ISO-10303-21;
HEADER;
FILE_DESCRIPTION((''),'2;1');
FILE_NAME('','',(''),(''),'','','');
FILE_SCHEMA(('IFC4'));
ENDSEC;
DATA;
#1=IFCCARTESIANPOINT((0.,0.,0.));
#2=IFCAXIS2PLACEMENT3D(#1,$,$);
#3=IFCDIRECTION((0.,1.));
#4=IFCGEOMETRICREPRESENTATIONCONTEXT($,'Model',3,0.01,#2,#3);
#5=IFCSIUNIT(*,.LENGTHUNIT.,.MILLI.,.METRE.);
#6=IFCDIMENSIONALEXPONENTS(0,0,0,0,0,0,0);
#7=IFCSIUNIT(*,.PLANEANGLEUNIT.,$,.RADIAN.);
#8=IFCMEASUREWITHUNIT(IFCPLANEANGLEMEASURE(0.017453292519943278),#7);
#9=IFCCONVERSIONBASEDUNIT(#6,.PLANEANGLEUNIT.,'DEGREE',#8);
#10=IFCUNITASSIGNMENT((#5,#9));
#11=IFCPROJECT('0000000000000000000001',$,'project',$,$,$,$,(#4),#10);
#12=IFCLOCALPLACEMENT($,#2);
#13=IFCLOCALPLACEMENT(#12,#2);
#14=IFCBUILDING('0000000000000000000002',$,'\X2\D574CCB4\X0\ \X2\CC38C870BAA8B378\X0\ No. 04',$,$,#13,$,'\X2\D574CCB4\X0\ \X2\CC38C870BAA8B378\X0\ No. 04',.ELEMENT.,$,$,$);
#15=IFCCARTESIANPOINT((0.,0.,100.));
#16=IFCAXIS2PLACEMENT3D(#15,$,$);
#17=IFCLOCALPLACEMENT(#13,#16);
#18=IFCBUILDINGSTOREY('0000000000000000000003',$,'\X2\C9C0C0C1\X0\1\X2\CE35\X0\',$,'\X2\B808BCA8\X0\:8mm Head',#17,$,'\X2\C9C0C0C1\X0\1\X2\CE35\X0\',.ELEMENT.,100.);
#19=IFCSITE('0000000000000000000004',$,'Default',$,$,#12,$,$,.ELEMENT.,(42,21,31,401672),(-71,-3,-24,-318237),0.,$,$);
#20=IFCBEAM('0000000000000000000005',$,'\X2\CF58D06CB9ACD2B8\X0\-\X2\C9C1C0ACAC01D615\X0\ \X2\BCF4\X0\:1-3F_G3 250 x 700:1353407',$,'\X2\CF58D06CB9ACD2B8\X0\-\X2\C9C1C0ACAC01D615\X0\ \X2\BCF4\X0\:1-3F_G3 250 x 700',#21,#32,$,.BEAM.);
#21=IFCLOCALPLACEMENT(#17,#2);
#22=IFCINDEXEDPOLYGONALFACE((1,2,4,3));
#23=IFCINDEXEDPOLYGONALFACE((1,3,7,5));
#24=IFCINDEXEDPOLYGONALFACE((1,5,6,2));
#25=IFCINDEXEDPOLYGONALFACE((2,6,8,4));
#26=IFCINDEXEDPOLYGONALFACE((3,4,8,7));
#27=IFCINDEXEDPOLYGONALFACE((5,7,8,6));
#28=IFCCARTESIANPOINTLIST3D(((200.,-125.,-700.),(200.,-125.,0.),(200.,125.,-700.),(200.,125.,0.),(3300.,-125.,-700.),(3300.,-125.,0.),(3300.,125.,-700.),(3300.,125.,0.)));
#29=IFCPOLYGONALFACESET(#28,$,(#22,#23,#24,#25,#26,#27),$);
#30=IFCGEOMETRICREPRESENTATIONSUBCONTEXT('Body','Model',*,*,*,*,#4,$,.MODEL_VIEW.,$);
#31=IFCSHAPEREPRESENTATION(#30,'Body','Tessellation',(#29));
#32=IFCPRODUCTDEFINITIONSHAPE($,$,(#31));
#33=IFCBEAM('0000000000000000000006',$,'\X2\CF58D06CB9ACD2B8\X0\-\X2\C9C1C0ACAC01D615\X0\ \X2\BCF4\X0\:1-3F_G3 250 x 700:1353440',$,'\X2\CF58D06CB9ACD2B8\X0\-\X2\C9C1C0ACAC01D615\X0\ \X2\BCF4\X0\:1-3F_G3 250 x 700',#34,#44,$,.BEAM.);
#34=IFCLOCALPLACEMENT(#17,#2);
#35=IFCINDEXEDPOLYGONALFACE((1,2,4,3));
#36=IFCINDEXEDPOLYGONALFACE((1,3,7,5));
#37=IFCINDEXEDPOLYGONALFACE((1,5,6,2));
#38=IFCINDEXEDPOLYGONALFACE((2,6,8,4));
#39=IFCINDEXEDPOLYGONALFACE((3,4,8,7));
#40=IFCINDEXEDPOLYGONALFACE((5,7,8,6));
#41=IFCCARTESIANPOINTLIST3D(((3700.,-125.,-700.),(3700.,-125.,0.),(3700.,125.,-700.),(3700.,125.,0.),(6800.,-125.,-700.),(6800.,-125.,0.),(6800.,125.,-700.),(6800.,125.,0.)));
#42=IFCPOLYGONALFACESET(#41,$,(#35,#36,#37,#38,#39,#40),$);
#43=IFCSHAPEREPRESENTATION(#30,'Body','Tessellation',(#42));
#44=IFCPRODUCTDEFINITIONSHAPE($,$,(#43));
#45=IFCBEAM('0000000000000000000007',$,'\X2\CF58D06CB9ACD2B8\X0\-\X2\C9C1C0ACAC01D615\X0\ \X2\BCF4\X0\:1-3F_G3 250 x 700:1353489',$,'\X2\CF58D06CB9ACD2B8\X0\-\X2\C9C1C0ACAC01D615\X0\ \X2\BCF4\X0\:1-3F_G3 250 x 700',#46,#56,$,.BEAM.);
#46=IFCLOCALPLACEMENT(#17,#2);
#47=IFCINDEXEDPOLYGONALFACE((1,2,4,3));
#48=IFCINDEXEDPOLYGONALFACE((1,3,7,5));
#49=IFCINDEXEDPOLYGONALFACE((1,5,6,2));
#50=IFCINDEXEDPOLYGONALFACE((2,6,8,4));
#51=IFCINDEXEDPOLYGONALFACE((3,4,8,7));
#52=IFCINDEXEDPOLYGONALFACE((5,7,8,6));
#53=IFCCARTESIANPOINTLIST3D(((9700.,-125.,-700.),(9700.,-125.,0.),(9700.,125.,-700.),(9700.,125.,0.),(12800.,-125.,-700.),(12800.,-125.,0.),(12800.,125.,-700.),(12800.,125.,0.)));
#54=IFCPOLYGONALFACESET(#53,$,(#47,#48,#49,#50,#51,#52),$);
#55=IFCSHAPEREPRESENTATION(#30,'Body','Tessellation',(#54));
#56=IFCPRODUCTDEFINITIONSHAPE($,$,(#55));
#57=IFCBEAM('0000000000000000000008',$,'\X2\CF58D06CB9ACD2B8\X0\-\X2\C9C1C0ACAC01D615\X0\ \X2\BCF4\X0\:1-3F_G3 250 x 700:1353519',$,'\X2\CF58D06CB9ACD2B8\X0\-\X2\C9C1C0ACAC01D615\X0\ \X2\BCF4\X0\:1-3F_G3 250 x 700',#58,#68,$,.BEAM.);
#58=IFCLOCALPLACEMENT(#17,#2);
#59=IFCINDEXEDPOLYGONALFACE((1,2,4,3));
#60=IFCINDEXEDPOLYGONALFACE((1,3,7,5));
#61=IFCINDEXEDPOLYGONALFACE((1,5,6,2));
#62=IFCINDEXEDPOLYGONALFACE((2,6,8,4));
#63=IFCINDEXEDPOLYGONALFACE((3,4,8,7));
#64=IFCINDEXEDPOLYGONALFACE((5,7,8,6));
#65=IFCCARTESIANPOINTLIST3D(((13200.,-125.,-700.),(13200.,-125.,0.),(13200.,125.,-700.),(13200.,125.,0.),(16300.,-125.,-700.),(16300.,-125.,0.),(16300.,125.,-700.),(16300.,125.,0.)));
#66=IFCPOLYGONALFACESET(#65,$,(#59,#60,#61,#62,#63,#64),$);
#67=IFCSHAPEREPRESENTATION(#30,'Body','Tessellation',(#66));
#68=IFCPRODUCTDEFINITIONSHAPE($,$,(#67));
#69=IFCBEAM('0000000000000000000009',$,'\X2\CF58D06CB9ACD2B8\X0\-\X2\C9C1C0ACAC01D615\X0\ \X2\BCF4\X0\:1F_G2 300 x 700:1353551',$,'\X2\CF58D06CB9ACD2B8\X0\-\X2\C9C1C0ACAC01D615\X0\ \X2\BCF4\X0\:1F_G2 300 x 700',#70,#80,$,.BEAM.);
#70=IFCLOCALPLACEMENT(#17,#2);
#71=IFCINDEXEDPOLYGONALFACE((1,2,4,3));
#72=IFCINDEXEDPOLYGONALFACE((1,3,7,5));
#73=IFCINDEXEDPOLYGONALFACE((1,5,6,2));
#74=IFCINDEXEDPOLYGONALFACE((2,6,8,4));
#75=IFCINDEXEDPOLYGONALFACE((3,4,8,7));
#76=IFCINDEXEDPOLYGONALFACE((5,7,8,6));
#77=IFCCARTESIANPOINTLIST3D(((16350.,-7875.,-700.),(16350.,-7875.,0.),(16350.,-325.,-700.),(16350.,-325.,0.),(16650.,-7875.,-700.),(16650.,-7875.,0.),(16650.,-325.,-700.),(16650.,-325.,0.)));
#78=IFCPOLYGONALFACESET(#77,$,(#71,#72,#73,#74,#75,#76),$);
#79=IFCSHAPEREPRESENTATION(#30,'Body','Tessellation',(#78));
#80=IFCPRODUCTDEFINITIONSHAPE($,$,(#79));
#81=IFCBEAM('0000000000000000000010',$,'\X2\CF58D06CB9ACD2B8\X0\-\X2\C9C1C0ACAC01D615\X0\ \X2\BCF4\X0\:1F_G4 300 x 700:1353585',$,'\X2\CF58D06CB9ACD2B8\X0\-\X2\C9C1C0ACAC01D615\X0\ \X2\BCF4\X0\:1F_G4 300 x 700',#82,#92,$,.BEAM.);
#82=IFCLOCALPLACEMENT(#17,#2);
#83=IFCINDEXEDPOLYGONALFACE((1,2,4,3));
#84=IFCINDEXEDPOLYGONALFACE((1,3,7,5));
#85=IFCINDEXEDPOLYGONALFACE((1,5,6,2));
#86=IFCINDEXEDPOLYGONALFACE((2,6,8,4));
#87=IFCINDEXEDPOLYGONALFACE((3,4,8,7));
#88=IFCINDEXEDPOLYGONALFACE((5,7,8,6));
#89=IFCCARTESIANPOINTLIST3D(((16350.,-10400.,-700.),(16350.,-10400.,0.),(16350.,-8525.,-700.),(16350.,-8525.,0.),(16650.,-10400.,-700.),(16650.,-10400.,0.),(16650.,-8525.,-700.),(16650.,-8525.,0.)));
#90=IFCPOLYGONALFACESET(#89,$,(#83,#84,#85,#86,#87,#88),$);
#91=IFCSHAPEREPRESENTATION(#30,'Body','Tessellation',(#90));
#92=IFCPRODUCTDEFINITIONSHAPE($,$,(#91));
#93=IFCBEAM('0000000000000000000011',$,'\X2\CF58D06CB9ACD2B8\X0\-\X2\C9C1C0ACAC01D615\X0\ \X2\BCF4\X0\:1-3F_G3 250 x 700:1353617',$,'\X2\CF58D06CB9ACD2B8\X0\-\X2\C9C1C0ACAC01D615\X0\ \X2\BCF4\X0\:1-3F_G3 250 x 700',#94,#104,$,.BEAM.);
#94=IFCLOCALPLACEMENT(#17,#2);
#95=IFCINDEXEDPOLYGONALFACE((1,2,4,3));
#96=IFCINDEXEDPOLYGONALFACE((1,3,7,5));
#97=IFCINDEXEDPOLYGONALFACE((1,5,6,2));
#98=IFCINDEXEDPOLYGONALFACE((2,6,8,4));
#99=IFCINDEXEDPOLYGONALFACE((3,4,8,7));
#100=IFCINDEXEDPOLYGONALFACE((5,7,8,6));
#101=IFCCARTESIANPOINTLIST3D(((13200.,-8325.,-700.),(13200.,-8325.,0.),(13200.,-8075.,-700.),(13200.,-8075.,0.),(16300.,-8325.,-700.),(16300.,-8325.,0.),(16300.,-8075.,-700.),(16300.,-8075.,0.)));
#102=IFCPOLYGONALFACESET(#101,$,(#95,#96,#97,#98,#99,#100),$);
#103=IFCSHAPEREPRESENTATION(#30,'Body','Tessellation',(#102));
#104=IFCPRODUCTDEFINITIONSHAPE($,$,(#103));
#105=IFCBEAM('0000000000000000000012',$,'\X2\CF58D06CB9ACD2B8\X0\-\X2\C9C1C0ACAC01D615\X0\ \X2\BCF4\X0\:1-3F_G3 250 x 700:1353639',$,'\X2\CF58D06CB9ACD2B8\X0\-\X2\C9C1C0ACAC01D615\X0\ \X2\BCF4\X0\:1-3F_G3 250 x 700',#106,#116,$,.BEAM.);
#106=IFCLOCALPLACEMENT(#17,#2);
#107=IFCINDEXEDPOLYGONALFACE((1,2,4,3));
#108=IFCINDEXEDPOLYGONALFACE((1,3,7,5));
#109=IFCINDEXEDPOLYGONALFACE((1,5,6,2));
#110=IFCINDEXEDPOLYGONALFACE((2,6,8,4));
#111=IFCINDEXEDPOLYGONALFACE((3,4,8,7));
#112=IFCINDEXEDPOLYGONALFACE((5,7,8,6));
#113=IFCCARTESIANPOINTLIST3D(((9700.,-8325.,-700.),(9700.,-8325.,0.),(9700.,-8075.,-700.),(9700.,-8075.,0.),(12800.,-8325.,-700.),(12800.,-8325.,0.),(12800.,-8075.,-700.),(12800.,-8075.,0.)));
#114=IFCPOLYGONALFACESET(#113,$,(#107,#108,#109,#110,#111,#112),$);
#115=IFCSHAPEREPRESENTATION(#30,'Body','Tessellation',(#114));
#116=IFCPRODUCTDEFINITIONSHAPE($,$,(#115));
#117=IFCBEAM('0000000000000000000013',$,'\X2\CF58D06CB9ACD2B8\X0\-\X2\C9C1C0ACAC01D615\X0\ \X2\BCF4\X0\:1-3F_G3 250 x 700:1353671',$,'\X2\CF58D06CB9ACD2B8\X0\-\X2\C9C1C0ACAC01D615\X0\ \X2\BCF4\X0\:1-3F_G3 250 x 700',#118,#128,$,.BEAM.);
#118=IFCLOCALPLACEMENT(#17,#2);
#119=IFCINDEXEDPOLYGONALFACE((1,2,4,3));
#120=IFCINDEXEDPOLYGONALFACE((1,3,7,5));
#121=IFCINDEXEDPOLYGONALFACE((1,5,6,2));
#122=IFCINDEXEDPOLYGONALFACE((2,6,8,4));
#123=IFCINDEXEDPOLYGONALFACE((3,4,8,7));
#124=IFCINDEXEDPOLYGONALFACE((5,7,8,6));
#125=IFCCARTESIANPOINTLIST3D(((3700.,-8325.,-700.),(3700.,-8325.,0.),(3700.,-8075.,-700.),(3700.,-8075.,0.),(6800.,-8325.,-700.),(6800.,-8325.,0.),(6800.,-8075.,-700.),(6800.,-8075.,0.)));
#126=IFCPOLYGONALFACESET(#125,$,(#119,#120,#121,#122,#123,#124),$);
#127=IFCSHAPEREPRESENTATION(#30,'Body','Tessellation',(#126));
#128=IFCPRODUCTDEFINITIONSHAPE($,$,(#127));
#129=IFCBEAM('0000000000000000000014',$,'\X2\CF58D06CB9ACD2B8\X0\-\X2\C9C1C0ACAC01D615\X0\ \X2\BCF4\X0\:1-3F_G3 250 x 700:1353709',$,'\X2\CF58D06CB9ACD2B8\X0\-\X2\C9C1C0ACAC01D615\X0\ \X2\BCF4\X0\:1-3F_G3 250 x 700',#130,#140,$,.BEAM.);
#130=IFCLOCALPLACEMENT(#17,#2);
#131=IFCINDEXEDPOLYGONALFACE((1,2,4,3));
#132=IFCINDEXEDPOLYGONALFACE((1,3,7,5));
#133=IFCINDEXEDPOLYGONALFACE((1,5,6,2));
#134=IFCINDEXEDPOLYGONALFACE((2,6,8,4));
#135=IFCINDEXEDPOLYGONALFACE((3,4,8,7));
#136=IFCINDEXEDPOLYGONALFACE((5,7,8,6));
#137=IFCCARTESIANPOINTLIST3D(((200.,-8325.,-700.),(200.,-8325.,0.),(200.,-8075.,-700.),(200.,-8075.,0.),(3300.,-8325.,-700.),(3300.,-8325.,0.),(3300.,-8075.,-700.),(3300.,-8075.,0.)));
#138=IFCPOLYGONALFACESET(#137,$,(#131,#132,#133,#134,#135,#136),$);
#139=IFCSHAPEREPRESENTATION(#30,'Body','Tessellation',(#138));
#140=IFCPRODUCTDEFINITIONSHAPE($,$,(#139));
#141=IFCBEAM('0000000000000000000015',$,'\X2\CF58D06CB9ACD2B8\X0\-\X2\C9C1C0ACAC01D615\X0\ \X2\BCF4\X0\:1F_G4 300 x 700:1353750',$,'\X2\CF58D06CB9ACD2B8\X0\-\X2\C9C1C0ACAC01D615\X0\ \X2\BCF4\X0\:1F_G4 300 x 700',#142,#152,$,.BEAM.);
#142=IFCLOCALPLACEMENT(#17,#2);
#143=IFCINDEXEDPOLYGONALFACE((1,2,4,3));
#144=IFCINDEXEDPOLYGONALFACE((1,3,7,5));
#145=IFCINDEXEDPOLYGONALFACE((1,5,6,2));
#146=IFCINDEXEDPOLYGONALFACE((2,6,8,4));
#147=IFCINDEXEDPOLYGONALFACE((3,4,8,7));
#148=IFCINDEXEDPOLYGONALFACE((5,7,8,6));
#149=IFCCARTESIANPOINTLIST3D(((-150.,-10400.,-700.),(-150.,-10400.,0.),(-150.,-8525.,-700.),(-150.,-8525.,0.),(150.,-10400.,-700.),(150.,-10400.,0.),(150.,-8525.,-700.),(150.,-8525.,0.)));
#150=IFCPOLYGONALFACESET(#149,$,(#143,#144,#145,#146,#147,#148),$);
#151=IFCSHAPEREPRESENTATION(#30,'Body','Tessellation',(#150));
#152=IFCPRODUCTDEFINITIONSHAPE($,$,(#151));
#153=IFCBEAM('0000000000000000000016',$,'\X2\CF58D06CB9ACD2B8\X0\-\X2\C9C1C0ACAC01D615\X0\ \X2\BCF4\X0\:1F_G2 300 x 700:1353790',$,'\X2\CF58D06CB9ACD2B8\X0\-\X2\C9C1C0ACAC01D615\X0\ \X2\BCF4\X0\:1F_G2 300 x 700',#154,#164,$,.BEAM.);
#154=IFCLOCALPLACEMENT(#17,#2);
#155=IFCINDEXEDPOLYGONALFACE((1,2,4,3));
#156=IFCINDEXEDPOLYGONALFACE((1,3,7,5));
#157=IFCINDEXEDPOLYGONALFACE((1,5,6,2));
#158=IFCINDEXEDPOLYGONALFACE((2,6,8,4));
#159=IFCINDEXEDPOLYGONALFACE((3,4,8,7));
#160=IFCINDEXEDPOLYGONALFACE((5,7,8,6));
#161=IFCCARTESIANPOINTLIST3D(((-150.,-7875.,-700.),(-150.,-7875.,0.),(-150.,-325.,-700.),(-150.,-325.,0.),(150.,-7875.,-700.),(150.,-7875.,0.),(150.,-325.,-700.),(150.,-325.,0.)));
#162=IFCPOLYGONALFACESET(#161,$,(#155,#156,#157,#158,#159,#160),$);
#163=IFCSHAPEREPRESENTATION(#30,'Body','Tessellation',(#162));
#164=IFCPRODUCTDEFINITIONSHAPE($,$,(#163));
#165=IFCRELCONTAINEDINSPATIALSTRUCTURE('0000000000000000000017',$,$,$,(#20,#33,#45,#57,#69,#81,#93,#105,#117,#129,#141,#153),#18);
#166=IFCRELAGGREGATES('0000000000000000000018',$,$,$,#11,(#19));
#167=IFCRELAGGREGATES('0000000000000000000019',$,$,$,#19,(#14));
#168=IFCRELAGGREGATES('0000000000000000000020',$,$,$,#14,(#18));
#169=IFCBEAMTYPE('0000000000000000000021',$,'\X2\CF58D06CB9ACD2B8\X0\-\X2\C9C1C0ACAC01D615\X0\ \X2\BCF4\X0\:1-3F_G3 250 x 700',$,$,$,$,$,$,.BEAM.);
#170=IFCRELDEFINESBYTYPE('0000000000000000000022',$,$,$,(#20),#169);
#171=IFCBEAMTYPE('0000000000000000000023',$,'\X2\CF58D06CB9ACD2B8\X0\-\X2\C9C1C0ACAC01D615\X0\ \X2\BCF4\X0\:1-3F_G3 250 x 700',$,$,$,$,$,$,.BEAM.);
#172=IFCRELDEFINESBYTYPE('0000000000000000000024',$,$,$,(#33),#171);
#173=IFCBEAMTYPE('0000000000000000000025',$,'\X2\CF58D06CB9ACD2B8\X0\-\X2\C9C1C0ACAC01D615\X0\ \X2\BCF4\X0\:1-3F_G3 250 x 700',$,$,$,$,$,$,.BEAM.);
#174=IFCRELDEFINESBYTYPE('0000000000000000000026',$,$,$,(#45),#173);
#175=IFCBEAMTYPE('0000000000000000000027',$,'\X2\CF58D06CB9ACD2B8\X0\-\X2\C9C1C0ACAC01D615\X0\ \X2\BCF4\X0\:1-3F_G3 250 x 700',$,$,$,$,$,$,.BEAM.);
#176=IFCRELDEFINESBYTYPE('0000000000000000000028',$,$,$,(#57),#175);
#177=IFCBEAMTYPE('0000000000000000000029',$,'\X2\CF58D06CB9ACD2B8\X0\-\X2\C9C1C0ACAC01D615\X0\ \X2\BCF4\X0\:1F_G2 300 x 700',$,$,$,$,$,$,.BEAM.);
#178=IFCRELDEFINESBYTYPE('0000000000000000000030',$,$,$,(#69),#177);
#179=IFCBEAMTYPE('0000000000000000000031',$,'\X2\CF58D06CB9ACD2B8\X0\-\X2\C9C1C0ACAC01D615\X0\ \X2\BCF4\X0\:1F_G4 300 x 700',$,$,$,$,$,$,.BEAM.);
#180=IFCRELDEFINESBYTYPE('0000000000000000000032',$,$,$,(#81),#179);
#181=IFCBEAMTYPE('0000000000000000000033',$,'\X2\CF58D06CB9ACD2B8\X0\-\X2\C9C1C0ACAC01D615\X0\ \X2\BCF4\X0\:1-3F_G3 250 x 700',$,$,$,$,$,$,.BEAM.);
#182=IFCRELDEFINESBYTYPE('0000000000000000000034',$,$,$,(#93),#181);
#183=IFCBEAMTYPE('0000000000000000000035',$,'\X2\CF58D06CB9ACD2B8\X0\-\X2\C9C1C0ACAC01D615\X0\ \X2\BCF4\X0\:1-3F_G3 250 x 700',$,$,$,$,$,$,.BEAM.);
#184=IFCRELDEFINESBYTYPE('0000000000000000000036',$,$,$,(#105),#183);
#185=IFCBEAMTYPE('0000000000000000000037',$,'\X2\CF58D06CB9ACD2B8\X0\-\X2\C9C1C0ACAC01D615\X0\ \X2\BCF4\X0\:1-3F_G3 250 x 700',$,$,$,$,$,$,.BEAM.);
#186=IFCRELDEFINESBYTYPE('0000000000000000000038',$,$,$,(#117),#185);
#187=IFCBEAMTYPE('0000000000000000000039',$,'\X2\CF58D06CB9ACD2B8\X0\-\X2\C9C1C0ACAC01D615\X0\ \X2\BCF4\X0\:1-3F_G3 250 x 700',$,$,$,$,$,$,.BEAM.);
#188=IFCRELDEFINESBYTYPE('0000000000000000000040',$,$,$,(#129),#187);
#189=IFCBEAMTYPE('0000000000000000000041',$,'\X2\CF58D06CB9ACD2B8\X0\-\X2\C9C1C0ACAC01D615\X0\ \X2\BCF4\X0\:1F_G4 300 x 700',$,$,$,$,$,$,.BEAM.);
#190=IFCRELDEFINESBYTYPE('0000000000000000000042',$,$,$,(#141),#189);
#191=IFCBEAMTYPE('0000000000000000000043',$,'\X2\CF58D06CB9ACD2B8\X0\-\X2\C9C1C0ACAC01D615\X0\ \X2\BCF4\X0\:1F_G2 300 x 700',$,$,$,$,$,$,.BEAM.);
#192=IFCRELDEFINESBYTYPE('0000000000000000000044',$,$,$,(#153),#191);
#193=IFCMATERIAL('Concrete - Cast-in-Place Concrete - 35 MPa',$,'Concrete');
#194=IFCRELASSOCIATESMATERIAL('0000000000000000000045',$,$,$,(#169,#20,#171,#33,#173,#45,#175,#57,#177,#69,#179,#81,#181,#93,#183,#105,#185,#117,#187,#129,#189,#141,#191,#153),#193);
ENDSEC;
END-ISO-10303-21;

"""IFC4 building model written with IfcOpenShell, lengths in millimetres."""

from ifc_helpers import new_model, entity, si_unit, converted_unit, direction, frame, origin, place, context, subcontext, project, spatial, indexed_curve, outline, extrude, source, transform, mapped, material, type_object, type_shapes, element, save


model = new_model("IFC4")

# Units and contexts
model_context = context("Model", 3, precision=0.01, world=origin(), true_north=direction((0.0, 1.0)))
body_context = subcontext(model_context, "Body", "Model", "MODEL_VIEW")
ifc_project = project(units=[si_unit("LENGTHUNIT", "METRE", prefix="MILLI"), converted_unit("PLANEANGLEUNIT", "DEGREE", entity("IfcPlaneAngleMeasure", 0.017453292519943278), si_unit("PLANEANGLEUNIT", "RADIAN"), dimensions=[0, 0, 0, 0, 0, 0, 0])], contexts=[model_context])

# Site, building, storey
site_placement = place(None, origin())
site = spatial("IfcSite", under=ifc_project, at=site_placement, Name="Default", CompositionType="ELEMENT", RefLatitude=(42, 21, 31, 401672), RefLongitude=(-71, -3, -24, -318237), RefElevation=0.0)
building_placement = place(site_placement, origin())
building = spatial("IfcBuilding", under=site, at=building_placement, Name="해체 참조모델 No. 04", LongName="해체 참조모델 No. 04", CompositionType="ELEMENT")
storey_placement = place(building_placement, frame((0.0, 0.0, 100.0)))
storey = spatial("IfcBuildingStorey", under=building, at=storey_placement, Name="지상1층", ObjectType="레벨:8mm Head", LongName="지상1층", CompositionType="ELEMENT", Elevation=100.0)

# Beams
ifc_material_1 = material(Name="Concrete - Cast-in-Place Concrete - 35 MPa", Category="Concrete")
beam_type_1 = type_object("IfcBeamType", Name="콘크리트-직사각형 보:1-3F_G3 250 x 700", PredefinedType="BEAM", material=ifc_material_1)
shared_shape_1 = source(origin(), body_context, "Body", "SweptSolid", [
    extrude(outline(indexed_curve([(-350.0, -125.0), (350.0, -125.0), (350.0, 125.0), (-350.0, 125.0), (-350.0, -125.0)], self_intersect=False)), frame((200.0, 0.0, -250.0), z_axis=(1.0, 0.0, 0.0), x_axis=(0.0, 0.0, -1.0)), (0.0, 0.0, 1.0), 3100.0),
])
type_shapes(beam_type_1, [shared_shape_1])
beam_1_placement = place(storey_placement, frame((0.0, 0.0, -100.0)))
element("IfcBeam", 1, at=beam_1_placement, inside=storey, type_object=beam_type_1, material=ifc_material_1, Name="콘크리트-직사각형 보:1-3F_G3 250 x 700:1353407", ObjectType="콘크리트-직사각형 보:1-3F_G3 250 x 700", PredefinedType="BEAM", context=body_context, shape_type="MappedRepresentation", body=[
    mapped(shared_shape_1, transform((0.0, 0.0, 0.0), scale=1.0)),
])
beam_type_2 = type_object("IfcBeamType", Name="콘크리트-직사각형 보:1-3F_G3 250 x 700", PredefinedType="BEAM", material=ifc_material_1)
shared_shape_2 = source(origin(), body_context, "Body", "SweptSolid", [
    extrude(outline(indexed_curve([(-350.0, -125.0), (350.0, -125.0), (350.0, 125.0), (-350.0, 125.0), (-350.0, -125.0)], self_intersect=False)), frame((3700.0, 0.0, -250.0), z_axis=(1.0, 0.0, 0.0), x_axis=(0.0, 0.0, -1.0)), (0.0, 0.0, 1.0), 3100.0),
])
type_shapes(beam_type_2, [shared_shape_2])
beam_2_placement = place(storey_placement, frame((0.0, 0.0, -100.0)))
element("IfcBeam", 2, at=beam_2_placement, inside=storey, type_object=beam_type_2, material=ifc_material_1, Name="콘크리트-직사각형 보:1-3F_G3 250 x 700:1353440", ObjectType="콘크리트-직사각형 보:1-3F_G3 250 x 700", PredefinedType="BEAM", context=body_context, shape_type="MappedRepresentation", body=[
    mapped(shared_shape_2, transform((0.0, 0.0, 0.0), scale=1.0)),
])
beam_type_3 = type_object("IfcBeamType", Name="콘크리트-직사각형 보:1-3F_G3 250 x 700", PredefinedType="BEAM", material=ifc_material_1)
shared_shape_3 = source(origin(), body_context, "Body", "SweptSolid", [
    extrude(outline(indexed_curve([(-350.0, -125.0), (350.0, -125.0), (350.0, 125.0), (-350.0, 125.0), (-350.0, -125.0)], self_intersect=False)), frame((9700.0, 0.0, -250.0), z_axis=(1.0, 0.0, 0.0), x_axis=(0.0, 0.0, -1.0)), (0.0, 0.0, 1.0), 3100.0),
])
type_shapes(beam_type_3, [shared_shape_3])
beam_3_placement = place(storey_placement, frame((0.0, 0.0, -100.0)))
element("IfcBeam", 3, at=beam_3_placement, inside=storey, type_object=beam_type_3, material=ifc_material_1, Name="콘크리트-직사각형 보:1-3F_G3 250 x 700:1353489", ObjectType="콘크리트-직사각형 보:1-3F_G3 250 x 700", PredefinedType="BEAM", context=body_context, shape_type="MappedRepresentation", body=[
    mapped(shared_shape_3, transform((0.0, 0.0, 0.0), scale=1.0)),
])
beam_type_4 = type_object("IfcBeamType", Name="콘크리트-직사각형 보:1-3F_G3 250 x 700", PredefinedType="BEAM", material=ifc_material_1)
shared_shape_4 = source(origin(), body_context, "Body", "SweptSolid", [
    extrude(outline(indexed_curve([(-350.0, -125.0), (350.0, -125.0), (350.0, 125.0), (-350.0, 125.0), (-350.0, -125.0)], self_intersect=False)), frame((13200.0, 0.0, -250.0), z_axis=(1.0, 0.0, 0.0), x_axis=(0.0, 0.0, -1.0)), (0.0, 0.0, 1.0), 3100.0),
])
type_shapes(beam_type_4, [shared_shape_4])
beam_4_placement = place(storey_placement, frame((0.0, 0.0, -100.0)))
element("IfcBeam", 4, at=beam_4_placement, inside=storey, type_object=beam_type_4, material=ifc_material_1, Name="콘크리트-직사각형 보:1-3F_G3 250 x 700:1353519", ObjectType="콘크리트-직사각형 보:1-3F_G3 250 x 700", PredefinedType="BEAM", context=body_context, shape_type="MappedRepresentation", body=[
    mapped(shared_shape_4, transform((0.0, 0.0, 0.0), scale=1.0)),
])
beam_type_5 = type_object("IfcBeamType", Name="콘크리트-직사각형 보:1F_G2 300 x 700", PredefinedType="BEAM", material=ifc_material_1)
shared_shape_5 = source(origin(), body_context, "Body", "SweptSolid", [
    extrude(outline(indexed_curve([(-150.0, -350.0), (150.0, -350.0), (150.0, 350.0), (-150.0, 350.0), (-150.0, -350.0)], self_intersect=False)), frame((16500.0, -325.0, -250.0), z_axis=(0.0, -1.0, 0.0), x_axis=(-1.0, 0.0, 0.0)), (0.0, 0.0, 1.0), 7550.0),
])
type_shapes(beam_type_5, [shared_shape_5])
beam_5_placement = place(storey_placement, frame((0.0, 0.0, -100.0)))
element("IfcBeam", 5, at=beam_5_placement, inside=storey, type_object=beam_type_5, material=ifc_material_1, Name="콘크리트-직사각형 보:1F_G2 300 x 700:1353551", ObjectType="콘크리트-직사각형 보:1F_G2 300 x 700", PredefinedType="BEAM", context=body_context, shape_type="MappedRepresentation", body=[
    mapped(shared_shape_5, transform((0.0, 0.0, 0.0), scale=1.0)),
])
beam_type_6 = type_object("IfcBeamType", Name="콘크리트-직사각형 보:1F_G4 300 x 700", PredefinedType="BEAM", material=ifc_material_1)
shared_shape_6 = source(origin(), body_context, "Body", "SweptSolid", [
    extrude(outline(indexed_curve([(-150.0, -350.0), (150.0, -350.0), (150.0, 350.0), (-150.0, 350.0), (-150.0, -350.0)], self_intersect=False)), frame((16500.0, -8525.0, -250.0), z_axis=(0.0, -1.0, 0.0), x_axis=(-1.0, 0.0, 0.0)), (0.0, 0.0, 1.0), 1875.0),
])
type_shapes(beam_type_6, [shared_shape_6])
beam_6_placement = place(storey_placement, frame((0.0, 0.0, -100.0)))
element("IfcBeam", 6, at=beam_6_placement, inside=storey, type_object=beam_type_6, material=ifc_material_1, Name="콘크리트-직사각형 보:1F_G4 300 x 700:1353585", ObjectType="콘크리트-직사각형 보:1F_G4 300 x 700", PredefinedType="BEAM", context=body_context, shape_type="MappedRepresentation", body=[
    mapped(shared_shape_6, transform((0.0, 0.0, 0.0), scale=1.0)),
])
beam_type_7 = type_object("IfcBeamType", Name="콘크리트-직사각형 보:1-3F_G3 250 x 700", PredefinedType="BEAM", material=ifc_material_1)
shared_shape_7 = source(origin(), body_context, "Body", "SweptSolid", [
    extrude(outline(indexed_curve([(-350.0, -125.0), (350.0, -125.0), (350.0, 125.0), (-350.0, 125.0), (-350.0, -125.0)], self_intersect=False)), frame((16300.0, -8200.0, -250.0), z_axis=(-1.0, 0.0, 0.0), x_axis=(0.0, 0.0, -1.0)), (0.0, 0.0, 1.0), 3100.0),
])
type_shapes(beam_type_7, [shared_shape_7])
beam_7_placement = place(storey_placement, frame((0.0, 0.0, -100.0)))
element("IfcBeam", 7, at=beam_7_placement, inside=storey, type_object=beam_type_7, material=ifc_material_1, Name="콘크리트-직사각형 보:1-3F_G3 250 x 700:1353617", ObjectType="콘크리트-직사각형 보:1-3F_G3 250 x 700", PredefinedType="BEAM", context=body_context, shape_type="MappedRepresentation", body=[
    mapped(shared_shape_7, transform((0.0, 0.0, 0.0), scale=1.0)),
])
beam_type_8 = type_object("IfcBeamType", Name="콘크리트-직사각형 보:1-3F_G3 250 x 700", PredefinedType="BEAM", material=ifc_material_1)
shared_shape_8 = source(origin(), body_context, "Body", "SweptSolid", [
    extrude(outline(indexed_curve([(-350.0, -125.0), (350.0, -125.0), (350.0, 125.0), (-350.0, 125.0), (-350.0, -125.0)], self_intersect=False)), frame((12800.0, -8200.0, -250.0), z_axis=(-1.0, 0.0, 0.0), x_axis=(0.0, 0.0, -1.0)), (0.0, 0.0, 1.0), 3100.0),
])
type_shapes(beam_type_8, [shared_shape_8])
beam_8_placement = place(storey_placement, frame((0.0, 0.0, -100.0)))
element("IfcBeam", 8, at=beam_8_placement, inside=storey, type_object=beam_type_8, material=ifc_material_1, Name="콘크리트-직사각형 보:1-3F_G3 250 x 700:1353639", ObjectType="콘크리트-직사각형 보:1-3F_G3 250 x 700", PredefinedType="BEAM", context=body_context, shape_type="MappedRepresentation", body=[
    mapped(shared_shape_8, transform((0.0, 0.0, 0.0), scale=1.0)),
])
beam_type_9 = type_object("IfcBeamType", Name="콘크리트-직사각형 보:1-3F_G3 250 x 700", PredefinedType="BEAM", material=ifc_material_1)
shared_shape_9 = source(origin(), body_context, "Body", "SweptSolid", [
    extrude(outline(indexed_curve([(-350.0, -125.0), (350.0, -125.0), (350.0, 125.0), (-350.0, 125.0), (-350.0, -125.0)], self_intersect=False)), frame((6800.0, -8200.0, -250.0), z_axis=(-1.0, 0.0, 0.0), x_axis=(0.0, 0.0, -1.0)), (0.0, 0.0, 1.0), 3100.0),
])
type_shapes(beam_type_9, [shared_shape_9])
beam_9_placement = place(storey_placement, frame((0.0, 0.0, -100.0)))
element("IfcBeam", 9, at=beam_9_placement, inside=storey, type_object=beam_type_9, material=ifc_material_1, Name="콘크리트-직사각형 보:1-3F_G3 250 x 700:1353671", ObjectType="콘크리트-직사각형 보:1-3F_G3 250 x 700", PredefinedType="BEAM", context=body_context, shape_type="MappedRepresentation", body=[
    mapped(shared_shape_9, transform((0.0, 0.0, 0.0), scale=1.0)),
])
beam_type_10 = type_object("IfcBeamType", Name="콘크리트-직사각형 보:1-3F_G3 250 x 700", PredefinedType="BEAM", material=ifc_material_1)
shared_shape_10 = source(origin(), body_context, "Body", "SweptSolid", [
    extrude(outline(indexed_curve([(-350.0, -125.0), (350.0, -125.0), (350.0, 125.0), (-350.0, 125.0), (-350.0, -125.0)], self_intersect=False)), frame((3300.0, -8200.0, -250.0), z_axis=(-1.0, 0.0, 0.0), x_axis=(0.0, 0.0, -1.0)), (0.0, 0.0, 1.0), 3100.0),
])
type_shapes(beam_type_10, [shared_shape_10])
beam_10_placement = place(storey_placement, frame((0.0, 0.0, -100.0)))
element("IfcBeam", 10, at=beam_10_placement, inside=storey, type_object=beam_type_10, material=ifc_material_1, Name="콘크리트-직사각형 보:1-3F_G3 250 x 700:1353709", ObjectType="콘크리트-직사각형 보:1-3F_G3 250 x 700", PredefinedType="BEAM", context=body_context, shape_type="MappedRepresentation", body=[
    mapped(shared_shape_10, transform((0.0, 0.0, 0.0), scale=1.0)),
])
beam_type_11 = type_object("IfcBeamType", Name="콘크리트-직사각형 보:1F_G4 300 x 700", PredefinedType="BEAM", material=ifc_material_1)
shared_shape_11 = source(origin(), body_context, "Body", "SweptSolid", [
    extrude(outline(indexed_curve([(-150.0, -350.0), (150.0, -350.0), (150.0, 350.0), (-150.0, 350.0), (-150.0, -350.0)], self_intersect=False)), frame((0.0, -10400.0, -250.0), z_axis=(0.0, 1.0, 0.0), x_axis=(-1.0, 0.0, 0.0)), (0.0, 0.0, 1.0), 1875.0),
])
type_shapes(beam_type_11, [shared_shape_11])
beam_11_placement = place(storey_placement, frame((0.0, 0.0, -100.0)))
element("IfcBeam", 11, at=beam_11_placement, inside=storey, type_object=beam_type_11, material=ifc_material_1, Name="콘크리트-직사각형 보:1F_G4 300 x 700:1353750", ObjectType="콘크리트-직사각형 보:1F_G4 300 x 700", PredefinedType="BEAM", context=body_context, shape_type="MappedRepresentation", body=[
    mapped(shared_shape_11, transform((0.0, 0.0, 0.0), scale=1.0)),
])
beam_type_12 = type_object("IfcBeamType", Name="콘크리트-직사각형 보:1F_G2 300 x 700", PredefinedType="BEAM", material=ifc_material_1)
shared_shape_12 = source(origin(), body_context, "Body", "SweptSolid", [
    extrude(outline(indexed_curve([(-150.0, -350.0), (150.0, -350.0), (150.0, 350.0), (-150.0, 350.0), (-150.0, -350.0)], self_intersect=False)), frame((0.0, -7875.0, -250.0), z_axis=(0.0, 1.0, 0.0), x_axis=(-1.0, 0.0, 0.0)), (0.0, 0.0, 1.0), 7550.0),
])
type_shapes(beam_type_12, [shared_shape_12])
beam_12_placement = place(storey_placement, frame((0.0, 0.0, -100.0)))
element("IfcBeam", 12, at=beam_12_placement, inside=storey, type_object=beam_type_12, material=ifc_material_1, Name="콘크리트-직사각형 보:1F_G2 300 x 700:1353790", ObjectType="콘크리트-직사각형 보:1F_G2 300 x 700", PredefinedType="BEAM", context=body_context, shape_type="MappedRepresentation", body=[
    mapped(shared_shape_12, transform((0.0, 0.0, 0.0), scale=1.0)),
])

save(model, "model.ifc")
